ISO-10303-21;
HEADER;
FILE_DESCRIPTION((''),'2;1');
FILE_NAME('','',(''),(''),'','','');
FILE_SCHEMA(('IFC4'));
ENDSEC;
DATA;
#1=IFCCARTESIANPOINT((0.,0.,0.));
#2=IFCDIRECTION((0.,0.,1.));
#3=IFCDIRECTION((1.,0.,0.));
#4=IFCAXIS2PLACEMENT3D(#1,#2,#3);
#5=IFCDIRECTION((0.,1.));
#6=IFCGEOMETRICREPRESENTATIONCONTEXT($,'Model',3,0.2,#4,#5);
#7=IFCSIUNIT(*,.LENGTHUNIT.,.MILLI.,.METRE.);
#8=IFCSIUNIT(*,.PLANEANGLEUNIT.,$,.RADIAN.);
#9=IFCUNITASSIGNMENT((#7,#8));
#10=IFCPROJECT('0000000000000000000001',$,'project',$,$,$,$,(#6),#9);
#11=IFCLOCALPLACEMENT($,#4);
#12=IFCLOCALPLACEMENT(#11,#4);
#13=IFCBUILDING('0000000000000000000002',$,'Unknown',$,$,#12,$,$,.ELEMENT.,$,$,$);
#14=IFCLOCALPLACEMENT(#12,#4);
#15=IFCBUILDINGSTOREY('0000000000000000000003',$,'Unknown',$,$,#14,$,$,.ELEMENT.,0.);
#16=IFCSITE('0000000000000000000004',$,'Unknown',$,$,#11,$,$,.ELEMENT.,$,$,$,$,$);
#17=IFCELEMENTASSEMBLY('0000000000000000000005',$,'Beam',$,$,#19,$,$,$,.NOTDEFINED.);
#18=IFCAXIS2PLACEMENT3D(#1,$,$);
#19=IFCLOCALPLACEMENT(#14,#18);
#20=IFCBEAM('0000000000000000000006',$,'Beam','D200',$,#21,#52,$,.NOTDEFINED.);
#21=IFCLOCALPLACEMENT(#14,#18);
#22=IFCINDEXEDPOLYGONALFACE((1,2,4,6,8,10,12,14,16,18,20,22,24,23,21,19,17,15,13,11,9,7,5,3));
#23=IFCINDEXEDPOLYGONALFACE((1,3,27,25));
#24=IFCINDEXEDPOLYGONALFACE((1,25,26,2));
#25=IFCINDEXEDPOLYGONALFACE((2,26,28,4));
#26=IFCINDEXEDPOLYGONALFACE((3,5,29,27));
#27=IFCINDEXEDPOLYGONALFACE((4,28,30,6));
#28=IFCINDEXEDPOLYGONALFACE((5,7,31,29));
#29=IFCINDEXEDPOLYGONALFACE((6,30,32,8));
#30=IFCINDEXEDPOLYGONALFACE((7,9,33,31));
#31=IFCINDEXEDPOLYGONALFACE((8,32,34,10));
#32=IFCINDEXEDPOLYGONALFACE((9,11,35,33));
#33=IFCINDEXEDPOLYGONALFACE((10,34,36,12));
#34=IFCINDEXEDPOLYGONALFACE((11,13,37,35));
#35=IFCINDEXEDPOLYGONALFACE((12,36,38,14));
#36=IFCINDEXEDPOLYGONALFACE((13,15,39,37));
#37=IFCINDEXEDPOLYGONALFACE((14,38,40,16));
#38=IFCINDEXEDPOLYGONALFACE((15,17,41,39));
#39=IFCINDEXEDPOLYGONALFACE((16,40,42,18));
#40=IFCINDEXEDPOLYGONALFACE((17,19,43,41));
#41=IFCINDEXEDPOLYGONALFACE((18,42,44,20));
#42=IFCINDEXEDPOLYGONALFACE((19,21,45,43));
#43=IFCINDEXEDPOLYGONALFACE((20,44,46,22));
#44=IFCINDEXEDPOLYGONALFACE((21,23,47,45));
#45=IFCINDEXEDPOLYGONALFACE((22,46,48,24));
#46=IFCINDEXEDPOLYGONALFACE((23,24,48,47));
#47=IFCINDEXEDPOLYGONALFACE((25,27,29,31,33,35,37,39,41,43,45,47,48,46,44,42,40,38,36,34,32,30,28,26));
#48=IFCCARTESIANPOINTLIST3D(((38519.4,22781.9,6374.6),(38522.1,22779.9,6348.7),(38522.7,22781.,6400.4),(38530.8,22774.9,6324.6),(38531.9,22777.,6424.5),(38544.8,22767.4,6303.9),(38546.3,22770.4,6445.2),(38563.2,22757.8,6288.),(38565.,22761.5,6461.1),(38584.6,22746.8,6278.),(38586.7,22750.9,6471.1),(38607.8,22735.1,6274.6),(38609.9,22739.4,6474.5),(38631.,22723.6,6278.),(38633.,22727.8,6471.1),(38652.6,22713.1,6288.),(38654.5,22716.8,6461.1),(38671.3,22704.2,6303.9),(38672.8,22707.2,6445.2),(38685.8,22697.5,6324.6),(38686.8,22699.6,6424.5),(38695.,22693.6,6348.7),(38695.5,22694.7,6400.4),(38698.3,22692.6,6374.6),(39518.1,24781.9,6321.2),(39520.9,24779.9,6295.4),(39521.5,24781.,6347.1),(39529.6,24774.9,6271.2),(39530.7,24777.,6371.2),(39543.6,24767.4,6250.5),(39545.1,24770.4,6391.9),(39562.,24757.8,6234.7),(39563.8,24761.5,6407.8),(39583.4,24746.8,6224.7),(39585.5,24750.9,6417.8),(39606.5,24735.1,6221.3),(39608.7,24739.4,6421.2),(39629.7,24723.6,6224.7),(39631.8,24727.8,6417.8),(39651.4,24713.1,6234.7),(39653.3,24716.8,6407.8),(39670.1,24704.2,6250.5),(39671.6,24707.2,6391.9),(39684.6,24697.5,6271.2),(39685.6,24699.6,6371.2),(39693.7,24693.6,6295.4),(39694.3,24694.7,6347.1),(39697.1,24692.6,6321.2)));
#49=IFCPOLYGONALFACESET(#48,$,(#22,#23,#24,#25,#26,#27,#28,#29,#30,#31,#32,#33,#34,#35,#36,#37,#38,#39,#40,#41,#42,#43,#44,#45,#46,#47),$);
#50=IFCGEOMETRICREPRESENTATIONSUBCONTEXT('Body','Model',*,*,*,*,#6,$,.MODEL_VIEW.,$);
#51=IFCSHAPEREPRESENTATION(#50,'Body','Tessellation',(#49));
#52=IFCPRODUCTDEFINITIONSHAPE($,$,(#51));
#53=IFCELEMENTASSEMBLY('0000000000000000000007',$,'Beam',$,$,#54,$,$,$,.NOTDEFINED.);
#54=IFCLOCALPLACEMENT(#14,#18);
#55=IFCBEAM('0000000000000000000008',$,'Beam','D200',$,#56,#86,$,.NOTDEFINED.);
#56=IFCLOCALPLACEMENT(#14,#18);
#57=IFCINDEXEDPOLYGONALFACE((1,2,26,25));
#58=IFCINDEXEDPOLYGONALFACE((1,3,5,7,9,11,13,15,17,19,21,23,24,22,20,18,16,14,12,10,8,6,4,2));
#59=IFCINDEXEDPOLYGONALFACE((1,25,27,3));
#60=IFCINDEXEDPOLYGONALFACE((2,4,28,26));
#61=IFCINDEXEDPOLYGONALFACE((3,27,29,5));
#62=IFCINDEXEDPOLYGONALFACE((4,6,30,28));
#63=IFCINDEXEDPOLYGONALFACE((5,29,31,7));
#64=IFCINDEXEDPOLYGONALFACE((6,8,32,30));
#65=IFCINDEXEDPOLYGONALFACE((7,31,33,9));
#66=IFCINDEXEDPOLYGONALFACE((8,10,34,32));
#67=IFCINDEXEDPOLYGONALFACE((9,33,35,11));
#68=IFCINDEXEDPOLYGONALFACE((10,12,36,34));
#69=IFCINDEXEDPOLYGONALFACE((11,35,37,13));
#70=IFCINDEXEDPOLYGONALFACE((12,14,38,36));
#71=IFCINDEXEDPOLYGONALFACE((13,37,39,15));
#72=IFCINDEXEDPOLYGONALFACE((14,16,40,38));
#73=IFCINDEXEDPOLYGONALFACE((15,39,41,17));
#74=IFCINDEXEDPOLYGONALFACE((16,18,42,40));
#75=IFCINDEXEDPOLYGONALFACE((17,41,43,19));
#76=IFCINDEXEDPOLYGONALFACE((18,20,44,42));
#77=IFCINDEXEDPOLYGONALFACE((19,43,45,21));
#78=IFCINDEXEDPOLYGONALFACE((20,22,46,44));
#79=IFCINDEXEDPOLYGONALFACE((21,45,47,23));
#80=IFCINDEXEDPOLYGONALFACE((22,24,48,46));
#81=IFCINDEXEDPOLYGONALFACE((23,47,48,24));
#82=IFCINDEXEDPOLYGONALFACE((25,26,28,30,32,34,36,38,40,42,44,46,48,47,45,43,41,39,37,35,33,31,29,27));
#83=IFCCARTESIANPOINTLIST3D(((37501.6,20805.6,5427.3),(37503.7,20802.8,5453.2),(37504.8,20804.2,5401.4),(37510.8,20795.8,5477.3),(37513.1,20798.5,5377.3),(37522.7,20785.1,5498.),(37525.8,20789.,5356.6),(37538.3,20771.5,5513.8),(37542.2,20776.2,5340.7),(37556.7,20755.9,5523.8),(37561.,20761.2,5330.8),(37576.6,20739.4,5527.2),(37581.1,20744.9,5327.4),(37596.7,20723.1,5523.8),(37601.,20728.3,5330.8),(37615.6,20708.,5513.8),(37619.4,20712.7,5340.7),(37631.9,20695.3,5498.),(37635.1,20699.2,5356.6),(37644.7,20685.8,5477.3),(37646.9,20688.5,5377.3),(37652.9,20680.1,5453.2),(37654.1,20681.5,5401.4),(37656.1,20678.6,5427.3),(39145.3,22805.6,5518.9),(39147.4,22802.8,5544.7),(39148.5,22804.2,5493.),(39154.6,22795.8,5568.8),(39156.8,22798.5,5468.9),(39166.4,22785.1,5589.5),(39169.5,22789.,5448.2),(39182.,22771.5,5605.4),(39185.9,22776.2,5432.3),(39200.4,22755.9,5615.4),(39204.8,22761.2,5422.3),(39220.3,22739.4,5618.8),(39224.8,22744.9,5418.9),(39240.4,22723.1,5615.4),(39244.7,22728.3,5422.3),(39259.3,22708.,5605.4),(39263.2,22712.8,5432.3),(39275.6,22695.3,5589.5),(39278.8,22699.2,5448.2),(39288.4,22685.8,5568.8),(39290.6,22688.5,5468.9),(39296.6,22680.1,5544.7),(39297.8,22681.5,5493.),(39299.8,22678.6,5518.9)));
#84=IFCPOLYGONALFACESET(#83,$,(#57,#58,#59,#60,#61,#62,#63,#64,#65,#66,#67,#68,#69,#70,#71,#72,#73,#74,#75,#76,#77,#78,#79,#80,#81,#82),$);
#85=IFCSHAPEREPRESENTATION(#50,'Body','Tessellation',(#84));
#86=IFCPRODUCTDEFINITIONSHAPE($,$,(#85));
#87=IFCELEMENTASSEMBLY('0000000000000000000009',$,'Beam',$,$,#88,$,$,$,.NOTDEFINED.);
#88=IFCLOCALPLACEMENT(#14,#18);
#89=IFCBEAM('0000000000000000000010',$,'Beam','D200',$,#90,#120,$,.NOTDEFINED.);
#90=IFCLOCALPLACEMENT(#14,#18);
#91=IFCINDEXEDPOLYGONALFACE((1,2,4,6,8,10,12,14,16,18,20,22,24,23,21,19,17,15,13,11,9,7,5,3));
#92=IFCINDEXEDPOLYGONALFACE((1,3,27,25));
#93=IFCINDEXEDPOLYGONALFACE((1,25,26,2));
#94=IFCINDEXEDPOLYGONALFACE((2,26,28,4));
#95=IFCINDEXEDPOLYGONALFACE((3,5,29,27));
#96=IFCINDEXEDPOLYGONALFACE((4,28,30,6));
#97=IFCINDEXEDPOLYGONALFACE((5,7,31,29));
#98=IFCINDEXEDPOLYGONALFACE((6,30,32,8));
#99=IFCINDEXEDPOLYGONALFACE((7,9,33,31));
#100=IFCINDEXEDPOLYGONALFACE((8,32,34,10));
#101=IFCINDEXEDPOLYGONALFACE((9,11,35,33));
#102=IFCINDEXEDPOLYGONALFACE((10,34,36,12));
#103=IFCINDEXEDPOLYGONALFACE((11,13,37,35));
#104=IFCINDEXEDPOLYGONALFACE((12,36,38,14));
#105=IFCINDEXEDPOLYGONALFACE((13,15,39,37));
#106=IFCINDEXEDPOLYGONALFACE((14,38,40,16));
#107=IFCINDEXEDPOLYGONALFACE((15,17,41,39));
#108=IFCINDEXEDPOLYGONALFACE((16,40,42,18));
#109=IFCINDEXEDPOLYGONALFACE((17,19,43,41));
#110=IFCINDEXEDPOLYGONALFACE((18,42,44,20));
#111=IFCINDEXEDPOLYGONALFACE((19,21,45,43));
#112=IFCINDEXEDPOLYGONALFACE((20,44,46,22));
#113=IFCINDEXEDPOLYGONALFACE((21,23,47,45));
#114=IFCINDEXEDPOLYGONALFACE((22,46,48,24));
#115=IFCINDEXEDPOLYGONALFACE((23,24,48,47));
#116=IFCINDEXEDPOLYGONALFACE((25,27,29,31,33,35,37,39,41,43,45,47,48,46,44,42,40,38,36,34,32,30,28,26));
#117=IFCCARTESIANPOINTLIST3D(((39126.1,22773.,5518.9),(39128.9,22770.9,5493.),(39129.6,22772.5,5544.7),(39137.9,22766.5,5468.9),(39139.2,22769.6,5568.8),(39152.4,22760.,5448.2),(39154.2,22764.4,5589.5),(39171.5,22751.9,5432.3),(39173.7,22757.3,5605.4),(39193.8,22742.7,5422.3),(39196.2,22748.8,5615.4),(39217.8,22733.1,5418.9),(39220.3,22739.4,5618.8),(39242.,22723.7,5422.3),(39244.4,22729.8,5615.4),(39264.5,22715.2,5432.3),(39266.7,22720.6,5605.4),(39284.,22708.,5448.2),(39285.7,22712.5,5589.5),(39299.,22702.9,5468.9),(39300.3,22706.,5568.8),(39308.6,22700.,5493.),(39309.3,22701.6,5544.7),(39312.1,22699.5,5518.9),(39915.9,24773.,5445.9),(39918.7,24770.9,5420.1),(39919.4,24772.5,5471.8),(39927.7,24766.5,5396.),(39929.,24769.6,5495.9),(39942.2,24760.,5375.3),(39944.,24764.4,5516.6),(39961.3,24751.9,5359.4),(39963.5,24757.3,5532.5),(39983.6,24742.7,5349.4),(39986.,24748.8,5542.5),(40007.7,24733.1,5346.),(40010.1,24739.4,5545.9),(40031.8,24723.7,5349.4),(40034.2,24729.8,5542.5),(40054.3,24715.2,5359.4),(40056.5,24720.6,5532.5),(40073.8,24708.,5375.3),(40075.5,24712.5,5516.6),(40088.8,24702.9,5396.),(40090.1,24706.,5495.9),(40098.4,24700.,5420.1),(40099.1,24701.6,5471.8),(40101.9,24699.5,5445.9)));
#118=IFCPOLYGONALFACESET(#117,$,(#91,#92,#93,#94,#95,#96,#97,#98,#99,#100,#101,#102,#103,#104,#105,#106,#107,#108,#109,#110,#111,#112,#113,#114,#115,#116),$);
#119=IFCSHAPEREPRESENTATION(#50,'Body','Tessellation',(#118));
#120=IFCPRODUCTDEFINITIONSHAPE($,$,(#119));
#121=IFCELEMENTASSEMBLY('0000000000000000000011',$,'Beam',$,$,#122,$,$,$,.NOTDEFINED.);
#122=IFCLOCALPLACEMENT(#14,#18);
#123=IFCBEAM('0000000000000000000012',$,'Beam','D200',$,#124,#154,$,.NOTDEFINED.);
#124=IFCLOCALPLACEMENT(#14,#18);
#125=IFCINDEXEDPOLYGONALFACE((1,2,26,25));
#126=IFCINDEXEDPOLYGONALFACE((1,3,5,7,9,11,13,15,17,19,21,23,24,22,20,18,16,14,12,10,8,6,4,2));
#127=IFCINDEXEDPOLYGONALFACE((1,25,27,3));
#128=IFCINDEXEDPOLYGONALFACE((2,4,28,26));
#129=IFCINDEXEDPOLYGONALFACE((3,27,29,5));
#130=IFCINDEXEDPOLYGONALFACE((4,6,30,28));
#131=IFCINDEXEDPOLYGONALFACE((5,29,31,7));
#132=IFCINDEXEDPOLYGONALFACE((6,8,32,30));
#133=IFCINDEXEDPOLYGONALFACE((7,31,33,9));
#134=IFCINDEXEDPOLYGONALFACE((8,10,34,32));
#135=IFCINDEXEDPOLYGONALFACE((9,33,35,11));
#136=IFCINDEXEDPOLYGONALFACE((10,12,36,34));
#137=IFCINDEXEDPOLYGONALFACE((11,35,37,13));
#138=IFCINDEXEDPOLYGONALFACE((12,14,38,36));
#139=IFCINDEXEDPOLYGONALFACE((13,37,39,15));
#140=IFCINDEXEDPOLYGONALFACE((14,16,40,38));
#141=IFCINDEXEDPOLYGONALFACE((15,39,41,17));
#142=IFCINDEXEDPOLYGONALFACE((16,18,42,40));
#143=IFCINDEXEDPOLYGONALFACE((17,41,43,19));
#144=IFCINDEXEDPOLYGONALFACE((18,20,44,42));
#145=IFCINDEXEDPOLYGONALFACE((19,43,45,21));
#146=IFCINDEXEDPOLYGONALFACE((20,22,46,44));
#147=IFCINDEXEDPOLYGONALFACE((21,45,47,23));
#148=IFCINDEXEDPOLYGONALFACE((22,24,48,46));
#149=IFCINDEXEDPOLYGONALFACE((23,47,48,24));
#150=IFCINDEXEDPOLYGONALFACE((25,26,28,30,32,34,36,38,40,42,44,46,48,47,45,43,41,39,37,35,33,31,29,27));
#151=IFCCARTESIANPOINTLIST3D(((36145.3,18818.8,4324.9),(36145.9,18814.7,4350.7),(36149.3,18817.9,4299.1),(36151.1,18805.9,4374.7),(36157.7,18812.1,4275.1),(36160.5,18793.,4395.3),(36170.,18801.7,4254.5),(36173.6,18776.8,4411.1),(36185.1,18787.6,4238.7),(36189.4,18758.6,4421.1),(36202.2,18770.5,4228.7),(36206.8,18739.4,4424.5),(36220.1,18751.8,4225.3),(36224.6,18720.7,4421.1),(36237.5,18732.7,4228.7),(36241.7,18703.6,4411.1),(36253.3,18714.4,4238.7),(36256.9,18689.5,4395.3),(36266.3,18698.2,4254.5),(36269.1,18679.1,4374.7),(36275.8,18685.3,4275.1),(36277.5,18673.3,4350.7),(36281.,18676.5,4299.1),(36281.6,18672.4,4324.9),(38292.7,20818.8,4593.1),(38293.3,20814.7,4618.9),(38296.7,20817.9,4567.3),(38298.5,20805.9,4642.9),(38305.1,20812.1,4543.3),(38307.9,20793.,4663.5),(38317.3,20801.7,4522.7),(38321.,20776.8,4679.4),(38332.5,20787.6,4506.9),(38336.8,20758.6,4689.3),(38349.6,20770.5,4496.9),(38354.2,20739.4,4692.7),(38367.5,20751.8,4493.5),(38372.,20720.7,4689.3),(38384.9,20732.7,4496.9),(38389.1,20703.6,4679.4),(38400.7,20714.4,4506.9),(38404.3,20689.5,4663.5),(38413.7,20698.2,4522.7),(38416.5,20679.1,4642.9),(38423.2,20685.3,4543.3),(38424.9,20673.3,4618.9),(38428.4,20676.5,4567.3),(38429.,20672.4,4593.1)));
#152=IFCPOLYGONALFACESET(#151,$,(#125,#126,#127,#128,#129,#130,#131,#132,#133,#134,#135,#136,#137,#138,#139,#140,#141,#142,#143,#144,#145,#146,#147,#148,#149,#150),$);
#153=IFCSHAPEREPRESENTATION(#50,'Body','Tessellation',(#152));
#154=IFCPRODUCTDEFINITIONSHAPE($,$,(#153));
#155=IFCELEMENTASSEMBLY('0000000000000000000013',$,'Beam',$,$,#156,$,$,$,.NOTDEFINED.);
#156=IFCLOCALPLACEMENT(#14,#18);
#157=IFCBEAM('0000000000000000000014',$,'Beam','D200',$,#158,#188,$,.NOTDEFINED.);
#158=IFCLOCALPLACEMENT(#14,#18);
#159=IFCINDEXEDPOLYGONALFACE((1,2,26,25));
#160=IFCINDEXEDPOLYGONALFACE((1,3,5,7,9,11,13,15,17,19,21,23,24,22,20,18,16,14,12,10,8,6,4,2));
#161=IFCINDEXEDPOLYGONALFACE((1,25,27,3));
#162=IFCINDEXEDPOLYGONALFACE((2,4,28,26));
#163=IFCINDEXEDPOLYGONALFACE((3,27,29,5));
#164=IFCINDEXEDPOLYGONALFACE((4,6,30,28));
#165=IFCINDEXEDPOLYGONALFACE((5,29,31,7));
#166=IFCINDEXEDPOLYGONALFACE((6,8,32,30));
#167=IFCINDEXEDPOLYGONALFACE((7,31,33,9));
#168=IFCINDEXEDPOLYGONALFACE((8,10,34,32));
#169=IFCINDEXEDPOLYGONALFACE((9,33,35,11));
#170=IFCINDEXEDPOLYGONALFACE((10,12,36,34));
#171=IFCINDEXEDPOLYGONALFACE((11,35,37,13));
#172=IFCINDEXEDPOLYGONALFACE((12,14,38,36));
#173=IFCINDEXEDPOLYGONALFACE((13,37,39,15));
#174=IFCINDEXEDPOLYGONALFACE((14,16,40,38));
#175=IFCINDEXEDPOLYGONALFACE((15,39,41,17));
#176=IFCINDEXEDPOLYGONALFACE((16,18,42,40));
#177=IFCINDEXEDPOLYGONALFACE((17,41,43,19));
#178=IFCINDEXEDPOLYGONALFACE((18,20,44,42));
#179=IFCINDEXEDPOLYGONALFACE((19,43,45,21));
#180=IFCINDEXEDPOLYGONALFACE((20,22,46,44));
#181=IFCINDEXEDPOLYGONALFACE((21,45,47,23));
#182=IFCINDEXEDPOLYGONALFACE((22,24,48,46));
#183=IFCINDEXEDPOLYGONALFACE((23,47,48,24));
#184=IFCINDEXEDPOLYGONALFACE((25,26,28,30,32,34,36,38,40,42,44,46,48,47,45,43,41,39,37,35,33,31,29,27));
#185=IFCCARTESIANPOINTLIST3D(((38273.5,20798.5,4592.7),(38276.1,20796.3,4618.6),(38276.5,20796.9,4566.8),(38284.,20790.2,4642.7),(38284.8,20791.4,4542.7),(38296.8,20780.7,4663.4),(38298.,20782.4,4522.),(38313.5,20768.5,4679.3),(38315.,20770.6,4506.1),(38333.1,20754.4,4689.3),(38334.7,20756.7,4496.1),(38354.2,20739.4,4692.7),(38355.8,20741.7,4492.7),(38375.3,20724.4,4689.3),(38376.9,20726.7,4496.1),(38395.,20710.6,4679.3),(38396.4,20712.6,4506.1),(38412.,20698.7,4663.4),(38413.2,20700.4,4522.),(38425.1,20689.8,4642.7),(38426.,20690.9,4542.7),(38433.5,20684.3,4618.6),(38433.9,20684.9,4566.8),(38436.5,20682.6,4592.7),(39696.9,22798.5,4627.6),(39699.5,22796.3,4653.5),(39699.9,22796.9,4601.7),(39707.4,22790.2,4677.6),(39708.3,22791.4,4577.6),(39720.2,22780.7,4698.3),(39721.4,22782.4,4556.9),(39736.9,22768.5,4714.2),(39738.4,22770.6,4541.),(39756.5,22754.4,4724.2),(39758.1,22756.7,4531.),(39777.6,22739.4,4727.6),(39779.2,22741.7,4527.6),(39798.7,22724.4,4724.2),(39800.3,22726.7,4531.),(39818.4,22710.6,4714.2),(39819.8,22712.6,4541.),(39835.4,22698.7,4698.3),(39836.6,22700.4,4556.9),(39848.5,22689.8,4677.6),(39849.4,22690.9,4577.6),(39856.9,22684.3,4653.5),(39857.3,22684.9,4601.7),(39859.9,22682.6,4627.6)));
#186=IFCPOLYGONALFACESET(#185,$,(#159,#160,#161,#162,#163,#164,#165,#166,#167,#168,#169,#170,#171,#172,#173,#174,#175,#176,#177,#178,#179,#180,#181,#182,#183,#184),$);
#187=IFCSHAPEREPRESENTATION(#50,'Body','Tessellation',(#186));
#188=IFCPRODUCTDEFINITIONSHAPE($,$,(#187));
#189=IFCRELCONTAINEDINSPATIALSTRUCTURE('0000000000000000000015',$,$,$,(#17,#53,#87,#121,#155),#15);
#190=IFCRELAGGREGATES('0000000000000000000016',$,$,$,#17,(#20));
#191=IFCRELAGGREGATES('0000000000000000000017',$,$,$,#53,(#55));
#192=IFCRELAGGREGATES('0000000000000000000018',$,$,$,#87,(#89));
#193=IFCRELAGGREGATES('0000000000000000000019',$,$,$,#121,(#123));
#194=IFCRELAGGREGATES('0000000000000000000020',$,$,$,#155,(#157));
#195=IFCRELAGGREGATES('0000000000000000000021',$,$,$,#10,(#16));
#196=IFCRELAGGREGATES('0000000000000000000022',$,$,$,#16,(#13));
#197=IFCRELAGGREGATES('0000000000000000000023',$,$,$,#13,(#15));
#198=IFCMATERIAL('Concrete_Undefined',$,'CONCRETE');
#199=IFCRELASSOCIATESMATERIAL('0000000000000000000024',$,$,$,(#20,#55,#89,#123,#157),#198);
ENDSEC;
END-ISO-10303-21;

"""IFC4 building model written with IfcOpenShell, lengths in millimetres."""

from ifc_helpers import new_model, si_unit, direction, frame, origin_with_axes, place, context, subcontext, project, spatial, line, indexed_curve, outline, extrude, material, element, aggregate, save


model = new_model("IFC4")

# Units and contexts
model_context = context("Model", 3, precision=0.2, world=origin_with_axes(), true_north=direction((0.0, 1.0)))
body_context = subcontext(model_context, "Body", "Model", "MODEL_VIEW")
ifc_project = project(units=[si_unit("LENGTHUNIT", "METRE", prefix="MILLI"), si_unit("PLANEANGLEUNIT", "RADIAN")], contexts=[model_context])

# Site, building, storey
site_placement = place(None, origin_with_axes())
site = spatial("IfcSite", under=ifc_project, at=site_placement, Name="Unknown", CompositionType="ELEMENT")
building_placement = place(site_placement, origin_with_axes())
building = spatial("IfcBuilding", under=site, at=building_placement, Name="Unknown", CompositionType="ELEMENT")
storey_placement = place(building_placement, origin_with_axes())
storey = spatial("IfcBuildingStorey", under=building, at=storey_placement, Name="Unknown", CompositionType="ELEMENT", Elevation=0.0)

# Element assemblies, beams
ifc_material = material(Name="Concrete_Undefined", Category="CONCRETE")
assembly_1_placement = place(storey_placement, frame((39607.6, 24737.3, 6321.2), z_axis=(-0.894645, 0.446777, 0.0), x_axis=(-0.44665, -0.894391, 0.023846)))
assembly_1 = element("IfcElementAssembly", 1, at=assembly_1_placement, inside=storey, Name="Beam", PredefinedType="NOTDEFINED")
beam_1_placement = place(assembly_1_placement, origin_with_axes())
beam_1 = element("IfcBeam", 2, at=beam_1_placement, material=ifc_material, Name="Beam", Description="D200", PredefinedType="NOTDEFINED", context=body_context, shape_type="SolidModel", body=[
    extrude(outline(indexed_curve([(100.0, 0.0), (96.6, 25.9), (86.6, 50.0), (70.7, 70.7), (50.0, 86.6), (25.9, 96.6), (0.0, 100.0), (-25.9, 96.6), (-50.0, 86.6), (-70.7, 70.7), (-86.6, 50.0), (-96.6, 25.9), (-100.0, 0.0), (-96.6, -25.9), (-86.6, -50.0), (-70.7, -70.7), (-50.0, -86.6), (-25.9, -96.6), (0.0, -100.0), (25.9, -96.6), (50.0, -86.6), (70.7, -70.7), (86.6, -50.0), (96.6, -25.9)], segments=[line(1, 2, 3, 4, 5, 6, 7, 8, 9, 10, 11, 12, 13, 14, 15, 16, 17, 18, 19, 20, 21, 22, 23, 24, 1)])), frame((0.0, 0.0, 0.0), z_axis=(-1.0, 0.0, 0.0), x_axis=(0.0, 0.0, 1.0)), (0.0, 0.0, -1.0), 2236.2),
])
aggregate(assembly_1, [beam_1])
assembly_2_placement = place(storey_placement, frame((39222.6, 22742.1, 5518.9), z_axis=(-0.772564, 0.634936, 0.0), x_axis=(-0.63454, -0.772081, -0.035352)))
assembly_2 = element("IfcElementAssembly", 3, at=assembly_2_placement, inside=storey, Name="Beam", PredefinedType="NOTDEFINED")
beam_2_placement = place(assembly_2_placement, origin_with_axes())
beam_2 = element("IfcBeam", 4, at=beam_2_placement, material=ifc_material, Name="Beam", Description="D200", PredefinedType="NOTDEFINED", context=body_context, shape_type="SolidModel", body=[
    extrude(outline(indexed_curve([(100.0, 0.0), (96.6, 25.9), (86.6, 50.0), (70.7, 70.7), (50.0, 86.6), (25.9, 96.6), (0.0, 100.0), (-25.9, 96.6), (-50.0, 86.6), (-70.7, 70.7), (-86.6, 50.0), (-96.6, 25.9), (-100.0, 0.0), (-96.6, -25.9), (-86.6, -50.0), (-70.7, -70.7), (-50.0, -86.6), (-25.9, -96.6), (0.0, -100.0), (25.9, -96.6), (50.0, -86.6), (70.7, -70.7), (86.6, -50.0), (96.6, -25.9)], segments=[line(1, 2, 3, 4, 5, 6, 7, 8, 9, 10, 11, 12, 13, 14, 15, 16, 17, 18, 19, 20, 21, 22, 23, 24, 1)])), frame((0.0, 0.0, 0.0), z_axis=(-1.0, 0.0, 0.0), x_axis=(0.0, 0.0, 1.0)), (0.0, 0.0, -1.0), 2590.4),
])
aggregate(assembly_2, [beam_2])
assembly_3_placement = place(storey_placement, frame((40008.9, 24736.2, 5445.9), z_axis=(-0.930103, 0.367298, 0.0), x_axis=(-0.367087, -0.929569, 0.033893)))
assembly_3 = element("IfcElementAssembly", 5, at=assembly_3_placement, inside=storey, Name="Beam", PredefinedType="NOTDEFINED")
beam_3_placement = place(assembly_3_placement, origin_with_axes())
beam_3 = element("IfcBeam", 6, at=beam_3_placement, material=ifc_material, Name="Beam", Description="D200", PredefinedType="NOTDEFINED", context=body_context, shape_type="SolidModel", body=[
    extrude(outline(indexed_curve([(100.0, 0.0), (96.6, 25.9), (86.6, 50.0), (70.7, 70.7), (50.0, 86.6), (25.9, 96.6), (0.0, 100.0), (-25.9, 96.6), (-50.0, 86.6), (-70.7, 70.7), (-86.6, 50.0), (-96.6, 25.9), (-100.0, 0.0), (-96.6, -25.9), (-86.6, -50.0), (-70.7, -70.7), (-50.0, -86.6), (-25.9, -96.6), (0.0, -100.0), (25.9, -96.6), (50.0, -86.6), (70.7, -70.7), (86.6, -50.0), (96.6, -25.9)], segments=[line(1, 2, 3, 4, 5, 6, 7, 8, 9, 10, 11, 12, 13, 14, 15, 16, 17, 18, 19, 20, 21, 22, 23, 24, 1)])), frame((0.0, 0.0, 0.0), z_axis=(-1.0, 0.0, 0.0), x_axis=(0.0, 0.0, 1.0)), (0.0, 0.0, -1.0), 2151.5),
])
aggregate(assembly_3, [beam_3])
assembly_4_placement = place(storey_placement, frame((38360.8, 20745.6, 4593.1), z_axis=(-0.681548, 0.731774, 0.0), x_axis=(-0.728736, -0.678718, -0.091022)))
assembly_4 = element("IfcElementAssembly", 7, at=assembly_4_placement, inside=storey, Name="Beam", PredefinedType="NOTDEFINED")
beam_4_placement = place(assembly_4_placement, origin_with_axes())
beam_4 = element("IfcBeam", 8, at=beam_4_placement, material=ifc_material, Name="Beam", Description="D200", PredefinedType="NOTDEFINED", context=body_context, shape_type="SolidModel", body=[
    extrude(outline(indexed_curve([(100.0, 0.0), (96.6, 25.9), (86.6, 50.0), (70.7, 70.7), (50.0, 86.6), (25.9, 96.6), (0.0, 100.0), (-25.9, 96.6), (-50.0, 86.6), (-70.7, 70.7), (-86.6, 50.0), (-96.6, 25.9), (-100.0, 0.0), (-96.6, -25.9), (-86.6, -50.0), (-70.7, -70.7), (-50.0, -86.6), (-25.9, -96.6), (0.0, -100.0), (25.9, -96.6), (50.0, -86.6), (70.7, -70.7), (86.6, -50.0), (96.6, -25.9)], segments=[line(1, 2, 3, 4, 5, 6, 7, 8, 9, 10, 11, 12, 13, 14, 15, 16, 17, 18, 19, 20, 21, 22, 23, 24, 1)])), frame((0.0, 0.0, 0.0), z_axis=(-1.0, 0.0, 0.0), x_axis=(0.0, 0.0, 1.0)), (0.0, 0.0, -1.0), 2946.7),
])
aggregate(assembly_4, [beam_4])
assembly_5_placement = place(storey_placement, frame((39778.4, 22740.6, 4627.6), z_axis=(-0.814728, 0.579843, 0.0), x_axis=(-0.579784, -0.814646, -0.01422)))
assembly_5 = element("IfcElementAssembly", 9, at=assembly_5_placement, inside=storey, Name="Beam", PredefinedType="NOTDEFINED")
beam_5_placement = place(assembly_5_placement, origin_with_axes())
beam_5 = element("IfcBeam", 10, at=beam_5_placement, material=ifc_material, Name="Beam", Description="D200", PredefinedType="NOTDEFINED", context=body_context, shape_type="SolidModel", body=[
    extrude(outline(indexed_curve([(100.0, 0.0), (96.6, 25.9), (86.6, 50.0), (70.7, 70.7), (50.0, 86.6), (25.9, 96.6), (0.0, 100.0), (-25.9, 96.6), (-50.0, 86.6), (-70.7, 70.7), (-86.6, 50.0), (-96.6, 25.9), (-100.0, 0.0), (-96.6, -25.9), (-86.6, -50.0), (-70.7, -70.7), (-50.0, -86.6), (-25.9, -96.6), (0.0, -100.0), (25.9, -96.6), (50.0, -86.6), (70.7, -70.7), (86.6, -50.0), (96.6, -25.9)], segments=[line(1, 2, 3, 4, 5, 6, 7, 8, 9, 10, 11, 12, 13, 14, 15, 16, 17, 18, 19, 20, 21, 22, 23, 24, 1)])), frame((0.0, 0.0, 0.0), z_axis=(-1.0, 0.0, 0.0), x_axis=(0.0, 0.0, 1.0)), (0.0, 0.0, -1.0), 2455.1),
])
aggregate(assembly_5, [beam_5])

save(model, "model.ifc")
